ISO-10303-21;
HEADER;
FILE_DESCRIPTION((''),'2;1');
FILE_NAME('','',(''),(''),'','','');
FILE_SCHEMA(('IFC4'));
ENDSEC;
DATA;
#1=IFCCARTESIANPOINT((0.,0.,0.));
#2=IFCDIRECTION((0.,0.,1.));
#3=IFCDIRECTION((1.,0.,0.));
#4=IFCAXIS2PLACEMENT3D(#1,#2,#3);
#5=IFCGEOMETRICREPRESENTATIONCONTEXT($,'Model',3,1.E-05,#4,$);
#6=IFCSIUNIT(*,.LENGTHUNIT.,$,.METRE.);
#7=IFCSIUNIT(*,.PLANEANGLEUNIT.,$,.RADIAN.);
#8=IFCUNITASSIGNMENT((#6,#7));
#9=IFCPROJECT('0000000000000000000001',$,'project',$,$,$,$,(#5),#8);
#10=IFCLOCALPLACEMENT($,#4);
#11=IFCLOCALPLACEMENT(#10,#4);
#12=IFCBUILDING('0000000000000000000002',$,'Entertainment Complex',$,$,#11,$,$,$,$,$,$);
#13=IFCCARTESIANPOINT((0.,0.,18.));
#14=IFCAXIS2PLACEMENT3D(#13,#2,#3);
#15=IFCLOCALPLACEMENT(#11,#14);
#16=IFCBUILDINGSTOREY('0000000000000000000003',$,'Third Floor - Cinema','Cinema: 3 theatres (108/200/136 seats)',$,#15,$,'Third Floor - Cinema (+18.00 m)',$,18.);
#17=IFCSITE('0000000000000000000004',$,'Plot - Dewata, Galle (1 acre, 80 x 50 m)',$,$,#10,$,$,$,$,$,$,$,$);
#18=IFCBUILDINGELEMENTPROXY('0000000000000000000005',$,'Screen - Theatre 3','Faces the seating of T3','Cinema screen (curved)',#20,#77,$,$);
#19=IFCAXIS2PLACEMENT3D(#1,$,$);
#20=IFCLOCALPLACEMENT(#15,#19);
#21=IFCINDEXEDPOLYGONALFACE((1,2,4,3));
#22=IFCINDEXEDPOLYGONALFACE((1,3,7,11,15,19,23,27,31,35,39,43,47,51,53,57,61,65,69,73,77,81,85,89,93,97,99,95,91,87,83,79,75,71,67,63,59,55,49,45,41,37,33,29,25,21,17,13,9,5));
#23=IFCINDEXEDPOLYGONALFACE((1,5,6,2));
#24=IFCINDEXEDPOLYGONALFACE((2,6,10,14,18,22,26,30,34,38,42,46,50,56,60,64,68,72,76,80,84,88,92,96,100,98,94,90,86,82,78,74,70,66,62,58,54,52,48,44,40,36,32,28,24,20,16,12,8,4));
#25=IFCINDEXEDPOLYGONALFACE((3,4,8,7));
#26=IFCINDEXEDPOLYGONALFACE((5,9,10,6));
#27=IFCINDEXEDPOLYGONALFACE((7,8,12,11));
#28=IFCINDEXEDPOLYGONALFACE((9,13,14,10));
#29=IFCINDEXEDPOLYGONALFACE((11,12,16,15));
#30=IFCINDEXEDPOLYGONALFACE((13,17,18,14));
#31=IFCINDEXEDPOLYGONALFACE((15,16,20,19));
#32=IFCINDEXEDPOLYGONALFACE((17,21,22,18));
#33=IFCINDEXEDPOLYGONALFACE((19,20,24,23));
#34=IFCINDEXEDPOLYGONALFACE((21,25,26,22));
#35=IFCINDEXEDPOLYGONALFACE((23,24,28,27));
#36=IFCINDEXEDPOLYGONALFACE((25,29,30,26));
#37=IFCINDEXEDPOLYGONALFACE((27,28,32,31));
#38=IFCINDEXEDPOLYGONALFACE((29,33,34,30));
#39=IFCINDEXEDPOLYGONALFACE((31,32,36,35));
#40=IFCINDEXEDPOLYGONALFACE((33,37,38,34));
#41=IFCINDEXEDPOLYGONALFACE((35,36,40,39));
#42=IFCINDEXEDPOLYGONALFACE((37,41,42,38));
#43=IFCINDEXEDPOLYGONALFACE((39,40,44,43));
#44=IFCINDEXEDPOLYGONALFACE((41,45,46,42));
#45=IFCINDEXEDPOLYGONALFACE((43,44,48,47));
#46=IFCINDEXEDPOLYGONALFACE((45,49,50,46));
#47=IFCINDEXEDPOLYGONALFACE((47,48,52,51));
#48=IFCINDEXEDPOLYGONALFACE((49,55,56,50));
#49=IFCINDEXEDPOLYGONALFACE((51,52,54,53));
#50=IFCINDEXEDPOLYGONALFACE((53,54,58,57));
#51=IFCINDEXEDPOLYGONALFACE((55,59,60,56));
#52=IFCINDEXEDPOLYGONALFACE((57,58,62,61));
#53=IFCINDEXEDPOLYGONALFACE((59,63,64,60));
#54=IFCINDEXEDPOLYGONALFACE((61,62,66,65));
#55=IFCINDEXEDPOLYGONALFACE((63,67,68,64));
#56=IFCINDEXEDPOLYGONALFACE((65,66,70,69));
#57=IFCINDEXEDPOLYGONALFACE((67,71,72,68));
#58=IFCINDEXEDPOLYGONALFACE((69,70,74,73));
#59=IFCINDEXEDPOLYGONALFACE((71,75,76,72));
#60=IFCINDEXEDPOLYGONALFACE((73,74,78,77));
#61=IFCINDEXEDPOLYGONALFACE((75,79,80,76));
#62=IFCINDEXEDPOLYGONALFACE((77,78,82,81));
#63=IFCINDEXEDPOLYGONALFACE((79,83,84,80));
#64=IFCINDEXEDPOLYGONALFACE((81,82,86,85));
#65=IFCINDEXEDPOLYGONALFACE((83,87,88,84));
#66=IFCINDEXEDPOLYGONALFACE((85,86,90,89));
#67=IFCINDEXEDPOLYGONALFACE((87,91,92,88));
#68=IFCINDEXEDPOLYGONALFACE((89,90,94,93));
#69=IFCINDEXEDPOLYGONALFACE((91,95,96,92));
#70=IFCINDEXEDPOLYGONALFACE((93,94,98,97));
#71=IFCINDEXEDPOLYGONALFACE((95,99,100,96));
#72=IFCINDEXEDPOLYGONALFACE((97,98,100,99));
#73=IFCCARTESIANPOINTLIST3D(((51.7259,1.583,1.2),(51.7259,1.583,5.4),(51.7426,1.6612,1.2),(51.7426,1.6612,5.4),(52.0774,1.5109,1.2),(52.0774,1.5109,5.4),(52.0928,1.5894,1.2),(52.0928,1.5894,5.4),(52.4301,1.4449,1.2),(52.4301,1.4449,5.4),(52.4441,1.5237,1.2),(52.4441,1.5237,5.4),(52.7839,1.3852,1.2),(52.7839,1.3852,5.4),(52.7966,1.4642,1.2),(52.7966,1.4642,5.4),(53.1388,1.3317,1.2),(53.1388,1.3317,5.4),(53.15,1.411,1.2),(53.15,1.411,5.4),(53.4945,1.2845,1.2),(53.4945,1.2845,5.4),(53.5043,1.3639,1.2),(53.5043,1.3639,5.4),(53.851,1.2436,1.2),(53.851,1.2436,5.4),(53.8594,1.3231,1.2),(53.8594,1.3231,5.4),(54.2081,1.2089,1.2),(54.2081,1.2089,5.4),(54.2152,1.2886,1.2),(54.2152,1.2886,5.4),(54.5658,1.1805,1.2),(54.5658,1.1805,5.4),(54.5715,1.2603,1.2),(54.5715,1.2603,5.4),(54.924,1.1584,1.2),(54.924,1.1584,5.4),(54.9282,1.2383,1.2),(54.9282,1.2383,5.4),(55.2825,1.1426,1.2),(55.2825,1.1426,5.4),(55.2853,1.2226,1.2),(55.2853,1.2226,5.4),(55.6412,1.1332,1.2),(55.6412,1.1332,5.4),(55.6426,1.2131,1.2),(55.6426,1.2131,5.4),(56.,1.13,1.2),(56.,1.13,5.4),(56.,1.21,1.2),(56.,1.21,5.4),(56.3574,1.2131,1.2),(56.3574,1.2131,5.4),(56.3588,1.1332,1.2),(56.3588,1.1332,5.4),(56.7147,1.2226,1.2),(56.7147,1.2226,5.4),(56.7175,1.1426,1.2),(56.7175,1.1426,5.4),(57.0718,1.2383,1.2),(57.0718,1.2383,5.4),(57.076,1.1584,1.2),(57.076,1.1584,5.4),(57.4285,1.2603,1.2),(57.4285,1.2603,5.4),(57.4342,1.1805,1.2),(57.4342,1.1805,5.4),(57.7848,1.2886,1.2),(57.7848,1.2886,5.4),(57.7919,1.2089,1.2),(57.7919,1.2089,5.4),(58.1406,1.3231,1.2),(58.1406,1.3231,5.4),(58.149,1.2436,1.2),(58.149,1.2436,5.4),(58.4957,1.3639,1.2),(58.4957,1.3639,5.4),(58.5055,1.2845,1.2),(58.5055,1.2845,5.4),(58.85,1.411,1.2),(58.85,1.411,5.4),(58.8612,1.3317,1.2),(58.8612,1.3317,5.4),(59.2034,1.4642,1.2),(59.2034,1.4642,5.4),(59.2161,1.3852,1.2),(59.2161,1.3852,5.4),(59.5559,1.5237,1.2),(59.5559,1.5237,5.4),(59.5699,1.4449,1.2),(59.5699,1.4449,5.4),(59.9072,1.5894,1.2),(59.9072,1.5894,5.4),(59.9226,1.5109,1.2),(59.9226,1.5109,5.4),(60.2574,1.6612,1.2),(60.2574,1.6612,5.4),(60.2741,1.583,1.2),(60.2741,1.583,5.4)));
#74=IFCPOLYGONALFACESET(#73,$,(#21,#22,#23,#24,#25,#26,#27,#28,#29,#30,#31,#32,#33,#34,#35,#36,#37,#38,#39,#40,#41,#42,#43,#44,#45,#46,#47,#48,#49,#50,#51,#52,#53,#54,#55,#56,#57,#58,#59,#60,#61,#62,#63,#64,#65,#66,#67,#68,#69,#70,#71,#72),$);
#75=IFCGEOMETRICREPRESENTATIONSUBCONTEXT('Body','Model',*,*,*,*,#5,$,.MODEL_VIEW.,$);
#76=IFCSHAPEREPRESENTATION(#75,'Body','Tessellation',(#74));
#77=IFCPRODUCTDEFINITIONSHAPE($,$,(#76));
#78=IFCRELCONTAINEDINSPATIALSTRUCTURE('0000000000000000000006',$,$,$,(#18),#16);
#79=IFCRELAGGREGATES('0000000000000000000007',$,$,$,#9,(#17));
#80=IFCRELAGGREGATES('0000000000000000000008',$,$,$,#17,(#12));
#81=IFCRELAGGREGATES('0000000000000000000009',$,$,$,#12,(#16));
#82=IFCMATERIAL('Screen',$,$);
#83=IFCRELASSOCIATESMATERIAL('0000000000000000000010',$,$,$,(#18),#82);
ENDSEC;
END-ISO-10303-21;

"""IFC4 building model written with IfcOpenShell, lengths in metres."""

from ifc_helpers import new_model, si_unit, frame, origin_with_axes, place, context, subcontext, project, spatial, polyline, outline, extrude, material, element, save


model = new_model("IFC4")

# Units and contexts
model_context = context("Model", 3, precision=1e-05, world=origin_with_axes())
body_context = subcontext(model_context, "Body", "Model", "MODEL_VIEW")
ifc_project = project(units=[si_unit("LENGTHUNIT", "METRE"), si_unit("PLANEANGLEUNIT", "RADIAN")], contexts=[model_context])

# Site, building, storey
site_placement = place(None, origin_with_axes())
site = spatial("IfcSite", under=ifc_project, at=site_placement, Name="Plot - Dewata, Galle (1 acre, 80 x 50 m)")
building_placement = place(site_placement, origin_with_axes())
building = spatial("IfcBuilding", under=site, at=building_placement, Name="Entertainment Complex")
storey_placement = place(building_placement, frame((0.0, 0.0, 18.0), z_axis=(0.0, 0.0, 1.0), x_axis=(1.0, 0.0, 0.0)))
storey = spatial("IfcBuildingStorey", under=building, at=storey_placement, Name="Third Floor - Cinema", Description="Cinema: 3 theatres (108/200/136 seats)", LongName="Third Floor - Cinema (+18.00 m)", Elevation=18.0)

# Building element proxy
ifc_material_1 = material(Name="Screen")
proxy_1_placement = place(storey_placement, origin_with_axes())
element("IfcBuildingElementProxy", 1, at=proxy_1_placement, inside=storey, material=ifc_material_1, Name="Screen - Theatre 3", Description="Faces the seating of T3", ObjectType="Cinema screen (curved)", context=body_context, shape_type="SweptSolid", body=[
    extrude(outline(polyline([(51.7259, 1.583), (52.0774, 1.5109), (52.4301, 1.4449), (52.7839, 1.3852), (53.1388, 1.3317), (53.4945, 1.2845), (53.851, 1.2436), (54.2081, 1.2089), (54.5658, 1.1805), (54.924, 1.1584), (55.2825, 1.1426), (55.6412, 1.1332), (56.0, 1.13), (56.3588, 1.1332), (56.7175, 1.1426), (57.076, 1.1584), (57.4342, 1.1805), (57.7919, 1.2089), (58.149, 1.2436), (58.5055, 1.2845), (58.8612, 1.3317), (59.2161, 1.3852), (59.5699, 1.4449), (59.9226, 1.5109), (60.2741, 1.583), (60.2574, 1.6612), (59.9072, 1.5894), (59.5559, 1.5237), (59.2034, 1.4642), (58.85, 1.411), (58.4957, 1.3639), (58.1406, 1.3231), (57.7848, 1.2886), (57.4285, 1.2603), (57.0718, 1.2383), (56.7147, 1.2226), (56.3574, 1.2131), (56.0, 1.21), (55.6426, 1.2131), (55.2853, 1.2226), (54.9282, 1.2383), (54.5715, 1.2603), (54.2152, 1.2886), (53.8594, 1.3231), (53.5043, 1.3639), (53.15, 1.411), (52.7966, 1.4642), (52.4441, 1.5237), (52.0928, 1.5894), (51.7426, 1.6612), (51.7259, 1.583)])), frame((0.0, 0.0, 1.2), z_axis=(0.0, 0.0, 1.0), x_axis=(1.0, 0.0, 0.0)), (0.0, 0.0, 1.0), 4.2),
])

save(model, "model.ifc")
